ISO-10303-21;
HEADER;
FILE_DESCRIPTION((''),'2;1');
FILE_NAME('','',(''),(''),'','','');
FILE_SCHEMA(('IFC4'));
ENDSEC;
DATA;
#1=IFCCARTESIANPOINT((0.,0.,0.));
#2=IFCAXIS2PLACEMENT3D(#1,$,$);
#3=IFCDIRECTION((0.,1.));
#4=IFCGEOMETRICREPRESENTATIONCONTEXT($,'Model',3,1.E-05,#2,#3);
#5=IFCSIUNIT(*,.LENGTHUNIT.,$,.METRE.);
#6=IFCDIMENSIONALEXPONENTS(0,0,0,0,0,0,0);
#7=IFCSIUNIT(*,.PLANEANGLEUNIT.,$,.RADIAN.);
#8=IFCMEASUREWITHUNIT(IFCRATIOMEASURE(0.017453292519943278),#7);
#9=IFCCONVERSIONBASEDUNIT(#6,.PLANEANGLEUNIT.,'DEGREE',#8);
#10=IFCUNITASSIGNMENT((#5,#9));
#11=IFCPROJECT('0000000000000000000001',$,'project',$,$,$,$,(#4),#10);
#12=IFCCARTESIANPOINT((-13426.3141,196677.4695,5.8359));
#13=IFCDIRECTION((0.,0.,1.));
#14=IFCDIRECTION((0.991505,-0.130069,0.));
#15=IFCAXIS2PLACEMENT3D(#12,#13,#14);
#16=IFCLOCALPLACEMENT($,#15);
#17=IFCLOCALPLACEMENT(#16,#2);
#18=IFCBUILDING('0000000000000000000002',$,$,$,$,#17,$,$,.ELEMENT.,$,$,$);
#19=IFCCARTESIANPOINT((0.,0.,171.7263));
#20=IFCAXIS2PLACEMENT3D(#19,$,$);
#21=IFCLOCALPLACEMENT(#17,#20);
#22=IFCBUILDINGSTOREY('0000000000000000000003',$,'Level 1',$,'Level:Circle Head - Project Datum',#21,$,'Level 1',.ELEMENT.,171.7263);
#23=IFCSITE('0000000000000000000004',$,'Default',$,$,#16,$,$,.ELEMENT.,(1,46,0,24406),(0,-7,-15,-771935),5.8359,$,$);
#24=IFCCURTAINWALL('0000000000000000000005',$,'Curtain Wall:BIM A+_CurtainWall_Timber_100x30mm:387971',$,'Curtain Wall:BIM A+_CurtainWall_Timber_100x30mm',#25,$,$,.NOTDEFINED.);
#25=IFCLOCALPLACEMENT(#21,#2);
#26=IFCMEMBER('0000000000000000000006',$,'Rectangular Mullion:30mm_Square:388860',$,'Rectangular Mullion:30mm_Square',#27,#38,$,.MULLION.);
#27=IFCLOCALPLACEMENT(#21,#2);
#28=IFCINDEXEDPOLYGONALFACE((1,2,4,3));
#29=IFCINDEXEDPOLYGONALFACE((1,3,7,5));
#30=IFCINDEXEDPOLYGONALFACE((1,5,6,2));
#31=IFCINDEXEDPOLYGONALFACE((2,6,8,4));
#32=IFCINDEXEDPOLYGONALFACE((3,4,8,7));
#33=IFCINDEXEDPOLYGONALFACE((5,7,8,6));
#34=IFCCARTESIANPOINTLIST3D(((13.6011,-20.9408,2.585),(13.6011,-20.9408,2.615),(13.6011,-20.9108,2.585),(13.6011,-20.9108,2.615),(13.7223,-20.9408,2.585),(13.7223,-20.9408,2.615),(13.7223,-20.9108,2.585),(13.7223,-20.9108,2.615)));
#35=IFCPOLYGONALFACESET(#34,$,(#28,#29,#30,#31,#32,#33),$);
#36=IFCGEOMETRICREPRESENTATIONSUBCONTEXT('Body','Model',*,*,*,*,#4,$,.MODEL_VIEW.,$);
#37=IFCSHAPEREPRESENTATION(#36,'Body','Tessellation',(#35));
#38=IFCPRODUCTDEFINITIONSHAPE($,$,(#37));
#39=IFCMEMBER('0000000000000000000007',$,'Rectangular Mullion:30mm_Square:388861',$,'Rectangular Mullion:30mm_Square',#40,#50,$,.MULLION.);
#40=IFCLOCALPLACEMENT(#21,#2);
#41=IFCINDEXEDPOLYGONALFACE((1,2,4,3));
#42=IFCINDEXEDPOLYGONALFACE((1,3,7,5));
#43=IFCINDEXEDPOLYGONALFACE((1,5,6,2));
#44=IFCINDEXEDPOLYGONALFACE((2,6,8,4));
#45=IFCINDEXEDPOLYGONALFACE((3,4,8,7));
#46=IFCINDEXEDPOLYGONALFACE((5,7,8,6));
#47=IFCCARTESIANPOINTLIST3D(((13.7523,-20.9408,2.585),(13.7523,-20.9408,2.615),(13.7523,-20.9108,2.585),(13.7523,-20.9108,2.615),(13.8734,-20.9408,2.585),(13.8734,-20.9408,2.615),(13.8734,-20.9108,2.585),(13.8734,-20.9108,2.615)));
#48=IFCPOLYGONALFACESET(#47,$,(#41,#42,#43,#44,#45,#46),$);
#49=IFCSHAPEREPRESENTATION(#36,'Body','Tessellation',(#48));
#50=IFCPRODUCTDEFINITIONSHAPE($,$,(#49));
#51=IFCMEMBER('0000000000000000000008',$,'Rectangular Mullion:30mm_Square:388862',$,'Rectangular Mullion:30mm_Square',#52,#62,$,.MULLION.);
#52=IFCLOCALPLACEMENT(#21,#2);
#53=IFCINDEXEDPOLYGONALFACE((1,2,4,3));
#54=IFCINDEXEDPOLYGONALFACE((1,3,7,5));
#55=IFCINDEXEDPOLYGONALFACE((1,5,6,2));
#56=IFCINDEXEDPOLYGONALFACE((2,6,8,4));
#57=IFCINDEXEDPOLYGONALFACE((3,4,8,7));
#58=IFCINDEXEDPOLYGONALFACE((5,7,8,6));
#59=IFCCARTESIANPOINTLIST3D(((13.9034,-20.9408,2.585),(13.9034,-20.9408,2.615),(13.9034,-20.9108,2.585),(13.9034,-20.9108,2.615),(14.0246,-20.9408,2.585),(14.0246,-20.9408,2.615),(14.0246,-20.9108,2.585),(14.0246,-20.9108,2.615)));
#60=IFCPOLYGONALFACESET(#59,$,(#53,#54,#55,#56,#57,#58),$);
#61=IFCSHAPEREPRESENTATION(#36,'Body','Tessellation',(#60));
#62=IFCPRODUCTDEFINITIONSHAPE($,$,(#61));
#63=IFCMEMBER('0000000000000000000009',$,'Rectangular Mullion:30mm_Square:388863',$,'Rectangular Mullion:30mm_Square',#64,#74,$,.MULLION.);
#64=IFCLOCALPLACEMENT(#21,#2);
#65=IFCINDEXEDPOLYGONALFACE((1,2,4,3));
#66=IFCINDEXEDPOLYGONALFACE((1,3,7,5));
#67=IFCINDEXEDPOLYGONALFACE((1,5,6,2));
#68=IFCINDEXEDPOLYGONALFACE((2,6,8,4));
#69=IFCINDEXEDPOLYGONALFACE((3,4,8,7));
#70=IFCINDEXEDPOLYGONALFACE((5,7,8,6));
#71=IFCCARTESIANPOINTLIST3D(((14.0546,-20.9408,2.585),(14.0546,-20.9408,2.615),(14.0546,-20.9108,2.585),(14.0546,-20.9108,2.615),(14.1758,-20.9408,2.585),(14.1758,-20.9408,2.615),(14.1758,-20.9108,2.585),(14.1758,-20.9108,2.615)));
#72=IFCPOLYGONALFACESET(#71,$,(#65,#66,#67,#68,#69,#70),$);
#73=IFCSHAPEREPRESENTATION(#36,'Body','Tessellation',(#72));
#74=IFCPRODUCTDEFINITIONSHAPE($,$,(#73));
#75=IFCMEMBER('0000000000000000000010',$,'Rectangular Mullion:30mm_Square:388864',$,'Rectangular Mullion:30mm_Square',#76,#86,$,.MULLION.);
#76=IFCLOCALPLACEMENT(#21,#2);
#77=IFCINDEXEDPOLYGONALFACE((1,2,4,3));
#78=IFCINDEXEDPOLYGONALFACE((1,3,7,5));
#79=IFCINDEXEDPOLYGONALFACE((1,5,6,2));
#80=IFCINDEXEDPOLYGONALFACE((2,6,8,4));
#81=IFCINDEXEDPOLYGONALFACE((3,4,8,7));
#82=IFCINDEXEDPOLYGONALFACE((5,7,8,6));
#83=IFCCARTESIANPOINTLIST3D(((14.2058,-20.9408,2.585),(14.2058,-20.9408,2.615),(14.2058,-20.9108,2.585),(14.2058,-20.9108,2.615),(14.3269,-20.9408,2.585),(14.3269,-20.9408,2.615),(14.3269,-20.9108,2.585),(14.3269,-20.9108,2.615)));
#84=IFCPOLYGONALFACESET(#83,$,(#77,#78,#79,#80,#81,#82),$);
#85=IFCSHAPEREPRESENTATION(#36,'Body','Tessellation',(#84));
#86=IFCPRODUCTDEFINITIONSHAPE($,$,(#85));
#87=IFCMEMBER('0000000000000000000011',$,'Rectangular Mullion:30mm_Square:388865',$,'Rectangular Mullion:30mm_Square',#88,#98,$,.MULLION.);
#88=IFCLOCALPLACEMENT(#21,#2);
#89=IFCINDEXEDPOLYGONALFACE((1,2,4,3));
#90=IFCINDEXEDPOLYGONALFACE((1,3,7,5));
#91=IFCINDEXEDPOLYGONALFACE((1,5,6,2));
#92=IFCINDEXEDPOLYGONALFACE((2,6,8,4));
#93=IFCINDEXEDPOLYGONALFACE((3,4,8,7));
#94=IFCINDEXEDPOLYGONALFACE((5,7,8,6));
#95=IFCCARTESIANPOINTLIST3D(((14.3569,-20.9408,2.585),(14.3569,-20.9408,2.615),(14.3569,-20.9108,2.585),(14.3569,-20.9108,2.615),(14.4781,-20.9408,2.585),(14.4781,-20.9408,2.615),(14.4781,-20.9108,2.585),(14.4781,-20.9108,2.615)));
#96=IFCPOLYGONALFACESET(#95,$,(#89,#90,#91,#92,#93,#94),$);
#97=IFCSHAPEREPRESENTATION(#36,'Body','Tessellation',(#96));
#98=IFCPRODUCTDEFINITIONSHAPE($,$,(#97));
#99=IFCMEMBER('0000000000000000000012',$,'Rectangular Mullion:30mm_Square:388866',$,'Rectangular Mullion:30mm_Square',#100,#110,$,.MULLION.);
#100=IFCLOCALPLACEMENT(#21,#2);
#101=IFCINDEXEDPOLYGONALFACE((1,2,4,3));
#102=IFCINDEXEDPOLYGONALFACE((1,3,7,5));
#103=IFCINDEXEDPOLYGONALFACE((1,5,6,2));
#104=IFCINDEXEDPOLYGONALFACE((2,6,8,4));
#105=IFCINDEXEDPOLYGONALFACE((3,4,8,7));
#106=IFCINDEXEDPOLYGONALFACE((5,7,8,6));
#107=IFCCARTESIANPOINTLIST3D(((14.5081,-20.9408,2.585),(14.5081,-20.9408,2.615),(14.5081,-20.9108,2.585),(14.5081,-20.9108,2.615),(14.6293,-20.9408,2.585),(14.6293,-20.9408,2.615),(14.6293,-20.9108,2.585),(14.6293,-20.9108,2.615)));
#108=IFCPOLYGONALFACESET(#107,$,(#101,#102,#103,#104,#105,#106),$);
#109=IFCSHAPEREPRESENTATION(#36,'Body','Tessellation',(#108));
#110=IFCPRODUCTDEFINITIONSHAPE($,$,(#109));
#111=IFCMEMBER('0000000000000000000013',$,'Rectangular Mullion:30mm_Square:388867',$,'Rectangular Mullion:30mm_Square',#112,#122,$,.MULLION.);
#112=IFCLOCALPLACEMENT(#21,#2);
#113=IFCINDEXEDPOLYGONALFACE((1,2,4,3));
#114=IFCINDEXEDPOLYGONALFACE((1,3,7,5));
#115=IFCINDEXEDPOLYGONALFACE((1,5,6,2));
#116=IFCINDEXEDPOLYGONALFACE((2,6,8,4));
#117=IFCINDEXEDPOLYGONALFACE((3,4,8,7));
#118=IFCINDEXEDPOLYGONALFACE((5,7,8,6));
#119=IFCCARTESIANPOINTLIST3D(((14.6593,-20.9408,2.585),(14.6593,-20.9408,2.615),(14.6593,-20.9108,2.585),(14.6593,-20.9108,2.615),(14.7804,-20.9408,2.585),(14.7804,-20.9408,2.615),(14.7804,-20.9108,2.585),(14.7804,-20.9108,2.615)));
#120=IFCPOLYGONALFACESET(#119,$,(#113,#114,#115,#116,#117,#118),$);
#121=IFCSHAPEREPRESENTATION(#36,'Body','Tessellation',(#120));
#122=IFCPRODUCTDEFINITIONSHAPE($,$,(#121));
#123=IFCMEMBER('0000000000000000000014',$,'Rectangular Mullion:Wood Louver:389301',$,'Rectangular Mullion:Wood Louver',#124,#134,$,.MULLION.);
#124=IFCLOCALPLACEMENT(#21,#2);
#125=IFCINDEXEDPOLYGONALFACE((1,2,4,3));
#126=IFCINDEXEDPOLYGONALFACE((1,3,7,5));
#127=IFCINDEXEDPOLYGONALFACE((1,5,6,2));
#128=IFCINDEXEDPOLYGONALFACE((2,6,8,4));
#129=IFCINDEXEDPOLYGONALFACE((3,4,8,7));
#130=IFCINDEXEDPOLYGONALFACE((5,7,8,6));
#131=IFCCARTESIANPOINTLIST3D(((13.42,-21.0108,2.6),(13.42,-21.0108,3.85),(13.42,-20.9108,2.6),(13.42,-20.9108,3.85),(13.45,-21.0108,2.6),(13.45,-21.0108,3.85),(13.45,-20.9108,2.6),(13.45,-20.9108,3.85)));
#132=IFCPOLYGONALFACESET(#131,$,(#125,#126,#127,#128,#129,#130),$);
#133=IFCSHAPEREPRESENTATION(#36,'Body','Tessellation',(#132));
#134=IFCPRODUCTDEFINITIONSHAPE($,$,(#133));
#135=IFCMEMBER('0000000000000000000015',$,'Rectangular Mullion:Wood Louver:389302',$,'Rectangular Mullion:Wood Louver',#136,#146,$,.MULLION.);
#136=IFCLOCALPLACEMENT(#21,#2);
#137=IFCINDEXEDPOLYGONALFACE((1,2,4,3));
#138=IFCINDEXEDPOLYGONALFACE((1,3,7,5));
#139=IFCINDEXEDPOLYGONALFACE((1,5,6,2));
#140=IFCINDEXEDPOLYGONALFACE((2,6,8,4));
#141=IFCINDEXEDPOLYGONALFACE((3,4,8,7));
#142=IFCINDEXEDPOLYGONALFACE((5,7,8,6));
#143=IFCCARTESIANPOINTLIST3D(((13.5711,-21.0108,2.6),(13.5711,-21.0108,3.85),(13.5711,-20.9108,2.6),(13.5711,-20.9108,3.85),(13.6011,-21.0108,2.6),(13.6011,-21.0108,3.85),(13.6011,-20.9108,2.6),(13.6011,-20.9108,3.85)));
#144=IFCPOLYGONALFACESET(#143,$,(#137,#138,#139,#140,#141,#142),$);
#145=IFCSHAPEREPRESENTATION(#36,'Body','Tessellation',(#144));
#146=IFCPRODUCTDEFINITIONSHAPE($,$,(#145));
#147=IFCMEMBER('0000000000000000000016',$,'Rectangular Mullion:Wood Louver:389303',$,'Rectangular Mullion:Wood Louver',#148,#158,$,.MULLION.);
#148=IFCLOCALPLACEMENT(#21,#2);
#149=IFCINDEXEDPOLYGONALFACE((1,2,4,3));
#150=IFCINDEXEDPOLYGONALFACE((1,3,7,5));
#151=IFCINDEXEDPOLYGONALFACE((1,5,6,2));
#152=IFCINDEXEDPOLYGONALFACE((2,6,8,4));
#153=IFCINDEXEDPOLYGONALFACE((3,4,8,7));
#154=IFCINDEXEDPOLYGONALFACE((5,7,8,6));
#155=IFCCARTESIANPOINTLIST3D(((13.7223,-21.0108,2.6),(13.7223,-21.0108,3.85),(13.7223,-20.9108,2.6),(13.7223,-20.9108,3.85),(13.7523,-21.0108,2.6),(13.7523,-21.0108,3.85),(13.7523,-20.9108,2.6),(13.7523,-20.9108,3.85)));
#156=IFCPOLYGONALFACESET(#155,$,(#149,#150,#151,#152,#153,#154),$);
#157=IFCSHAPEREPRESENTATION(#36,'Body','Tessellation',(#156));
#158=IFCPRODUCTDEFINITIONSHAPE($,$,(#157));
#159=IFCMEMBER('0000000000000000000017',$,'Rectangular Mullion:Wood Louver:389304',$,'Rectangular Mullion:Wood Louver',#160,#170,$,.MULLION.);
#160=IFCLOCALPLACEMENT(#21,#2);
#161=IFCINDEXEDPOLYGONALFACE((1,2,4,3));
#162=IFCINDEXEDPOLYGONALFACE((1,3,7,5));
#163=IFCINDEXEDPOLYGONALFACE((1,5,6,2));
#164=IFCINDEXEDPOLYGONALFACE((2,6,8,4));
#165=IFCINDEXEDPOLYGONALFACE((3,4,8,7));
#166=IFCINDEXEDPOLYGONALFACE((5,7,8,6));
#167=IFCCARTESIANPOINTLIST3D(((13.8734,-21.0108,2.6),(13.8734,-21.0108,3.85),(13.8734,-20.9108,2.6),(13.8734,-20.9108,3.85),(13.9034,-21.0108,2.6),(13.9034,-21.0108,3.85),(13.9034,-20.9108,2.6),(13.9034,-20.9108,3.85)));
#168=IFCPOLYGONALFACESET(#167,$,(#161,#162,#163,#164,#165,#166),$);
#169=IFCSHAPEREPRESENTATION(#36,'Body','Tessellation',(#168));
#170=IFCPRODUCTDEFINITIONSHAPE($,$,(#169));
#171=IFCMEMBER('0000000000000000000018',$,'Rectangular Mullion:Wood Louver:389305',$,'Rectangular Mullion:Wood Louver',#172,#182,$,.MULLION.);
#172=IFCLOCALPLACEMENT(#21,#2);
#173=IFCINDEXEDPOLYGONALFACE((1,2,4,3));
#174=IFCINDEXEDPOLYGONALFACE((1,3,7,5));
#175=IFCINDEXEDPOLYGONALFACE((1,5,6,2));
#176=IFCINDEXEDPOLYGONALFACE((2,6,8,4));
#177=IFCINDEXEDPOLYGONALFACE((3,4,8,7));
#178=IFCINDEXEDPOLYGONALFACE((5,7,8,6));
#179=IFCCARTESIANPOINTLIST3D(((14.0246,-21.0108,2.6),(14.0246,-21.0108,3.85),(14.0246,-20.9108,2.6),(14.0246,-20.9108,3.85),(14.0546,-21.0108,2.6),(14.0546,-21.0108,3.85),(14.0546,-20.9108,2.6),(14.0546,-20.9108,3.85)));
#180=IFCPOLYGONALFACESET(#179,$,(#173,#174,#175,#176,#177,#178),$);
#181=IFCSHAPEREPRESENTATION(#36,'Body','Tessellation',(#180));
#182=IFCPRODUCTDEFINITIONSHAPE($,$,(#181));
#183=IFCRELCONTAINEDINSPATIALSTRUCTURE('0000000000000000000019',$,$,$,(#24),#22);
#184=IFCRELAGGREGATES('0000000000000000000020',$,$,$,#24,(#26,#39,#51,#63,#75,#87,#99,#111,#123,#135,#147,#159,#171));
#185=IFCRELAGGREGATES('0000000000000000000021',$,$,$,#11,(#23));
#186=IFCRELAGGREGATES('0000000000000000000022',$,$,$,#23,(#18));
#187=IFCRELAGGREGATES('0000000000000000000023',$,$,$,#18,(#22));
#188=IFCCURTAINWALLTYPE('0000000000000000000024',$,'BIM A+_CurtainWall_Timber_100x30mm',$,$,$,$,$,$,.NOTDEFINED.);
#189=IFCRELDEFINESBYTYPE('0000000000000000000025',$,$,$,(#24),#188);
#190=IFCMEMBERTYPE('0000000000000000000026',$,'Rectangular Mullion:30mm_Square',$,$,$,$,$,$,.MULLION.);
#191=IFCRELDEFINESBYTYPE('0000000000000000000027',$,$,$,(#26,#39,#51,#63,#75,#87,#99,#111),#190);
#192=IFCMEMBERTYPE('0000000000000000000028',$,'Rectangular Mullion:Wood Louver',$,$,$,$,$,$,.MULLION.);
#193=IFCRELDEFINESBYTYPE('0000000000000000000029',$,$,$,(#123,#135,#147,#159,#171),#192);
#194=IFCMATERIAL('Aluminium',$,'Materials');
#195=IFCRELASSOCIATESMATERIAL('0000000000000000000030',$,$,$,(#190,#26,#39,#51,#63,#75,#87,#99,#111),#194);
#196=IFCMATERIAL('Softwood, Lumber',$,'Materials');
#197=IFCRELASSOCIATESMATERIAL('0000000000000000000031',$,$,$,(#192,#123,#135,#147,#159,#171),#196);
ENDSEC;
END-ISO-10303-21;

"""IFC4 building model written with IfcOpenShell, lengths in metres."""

from ifc_helpers import new_model, entity, si_unit, converted_unit, direction, frame, origin, place, context, subcontext, project, spatial, indexed_curve, outline, extrude, source, transform, mapped, material, type_object, type_shapes, element, aggregate, save


model = new_model("IFC4")

# Units and contexts
model_context = context("Model", 3, precision=1e-05, world=origin(), true_north=direction((0.0, 1.0)))
body_context = subcontext(model_context, "Body", "Model", "MODEL_VIEW")
ifc_project = project(units=[si_unit("LENGTHUNIT", "METRE"), converted_unit("PLANEANGLEUNIT", "DEGREE", entity("IfcRatioMeasure", 0.017453292519943278), si_unit("PLANEANGLEUNIT", "RADIAN"), dimensions=[0, 0, 0, 0, 0, 0, 0])], contexts=[model_context])

# Site, building, storey
site_placement = place(None, frame((-13426.3141, 196677.4695, 5.8359), z_axis=(0.0, 0.0, 1.0), x_axis=(0.991505, -0.130069, 0.0)))
site = spatial("IfcSite", under=ifc_project, at=site_placement, Name="Default", CompositionType="ELEMENT", RefLatitude=(1, 46, 0, 24406), RefLongitude=(0, -7, -15, -771935), RefElevation=5.8359)
building_placement = place(site_placement, origin())
building = spatial("IfcBuilding", under=site, at=building_placement, CompositionType="ELEMENT")
storey_placement = place(building_placement, frame((0.0, 0.0, 171.7263)))
storey = spatial("IfcBuildingStorey", under=building, at=storey_placement, Name="Level 1", ObjectType="Level:Circle Head - Project Datum", LongName="Level 1", CompositionType="ELEMENT", Elevation=171.7263)

# Curtain wall, members
curtain_wall_type = type_object("IfcCurtainWallType", Name="BIM A+_CurtainWall_Timber_100x30mm", PredefinedType="NOTDEFINED")
curtain_wall_placement = place(storey_placement, frame((0.0, 0.0, -171.7263)))
curtain_wall = element("IfcCurtainWall", 1, at=curtain_wall_placement, inside=storey, type_object=curtain_wall_type, Name="Curtain Wall:BIM A+_CurtainWall_Timber_100x30mm:387971", ObjectType="Curtain Wall:BIM A+_CurtainWall_Timber_100x30mm", PredefinedType="NOTDEFINED")
ifc_material_1 = material(Name="Aluminium", Category="Materials")
member_type_1 = type_object("IfcMemberType", Name="Rectangular Mullion:30mm_Square", PredefinedType="MULLION", material=ifc_material_1)
shared_shape_1 = source(origin(), body_context, "Body", "SweptSolid", [
    extrude(outline(indexed_curve([(-0.015, -0.015), (0.015, -0.015), (0.015, 0.015), (-0.015, 0.015), (-0.015, -0.015)], self_intersect=False)), frame((0.0, 0.0, -0.1212), z_axis=(0.0, 0.0, 1.0), x_axis=(0.0, -1.0, 0.0)), (0.0, 0.0, 1.0), 0.1212),
])
type_shapes(member_type_1, [shared_shape_1])
member_1_placement = place(curtain_wall_placement, frame((13.7223, -20.9258, 174.3263), z_axis=(1.0, 0.0, 0.0), x_axis=(0.0, 0.0, 1.0)))
member_1 = element("IfcMember", 2, at=member_1_placement, type_object=member_type_1, material=ifc_material_1, Name="Rectangular Mullion:30mm_Square:388860", ObjectType="Rectangular Mullion:30mm_Square", PredefinedType="MULLION", context=body_context, shape_type="MappedRepresentation", body=[
    mapped(shared_shape_1, transform((0.0, 0.0, 0.0), scale=1.0)),
])
member_2_placement = place(curtain_wall_placement, frame((13.8734, -20.9258, 174.3263), z_axis=(1.0, 0.0, 0.0), x_axis=(0.0, 0.0, 1.0)))
member_2 = element("IfcMember", 3, at=member_2_placement, type_object=member_type_1, material=ifc_material_1, Name="Rectangular Mullion:30mm_Square:388861", ObjectType="Rectangular Mullion:30mm_Square", PredefinedType="MULLION", context=body_context, shape_type="MappedRepresentation", body=[
    mapped(shared_shape_1, transform((0.0, 0.0, 0.0), scale=1.0)),
])
member_3_placement = place(curtain_wall_placement, frame((14.0246, -20.9258, 174.3263), z_axis=(1.0, 0.0, 0.0), x_axis=(0.0, 0.0, 1.0)))
member_3 = element("IfcMember", 4, at=member_3_placement, type_object=member_type_1, material=ifc_material_1, Name="Rectangular Mullion:30mm_Square:388862", ObjectType="Rectangular Mullion:30mm_Square", PredefinedType="MULLION", context=body_context, shape_type="MappedRepresentation", body=[
    mapped(shared_shape_1, transform((0.0, 0.0, 0.0), scale=1.0)),
])
member_4_placement = place(curtain_wall_placement, frame((14.1758, -20.9258, 174.3263), z_axis=(1.0, 0.0, 0.0), x_axis=(0.0, 0.0, 1.0)))
member_4 = element("IfcMember", 5, at=member_4_placement, type_object=member_type_1, material=ifc_material_1, Name="Rectangular Mullion:30mm_Square:388863", ObjectType="Rectangular Mullion:30mm_Square", PredefinedType="MULLION", context=body_context, shape_type="MappedRepresentation", body=[
    mapped(shared_shape_1, transform((0.0, 0.0, 0.0), scale=1.0)),
])
member_5_placement = place(curtain_wall_placement, frame((14.3269, -20.9258, 174.3263), z_axis=(1.0, 0.0, 0.0), x_axis=(0.0, 0.0, 1.0)))
member_5 = element("IfcMember", 6, at=member_5_placement, type_object=member_type_1, material=ifc_material_1, Name="Rectangular Mullion:30mm_Square:388864", ObjectType="Rectangular Mullion:30mm_Square", PredefinedType="MULLION", context=body_context, shape_type="MappedRepresentation", body=[
    mapped(shared_shape_1, transform((0.0, 0.0, 0.0), scale=1.0)),
])
member_6_placement = place(curtain_wall_placement, frame((14.4781, -20.9258, 174.3263), z_axis=(1.0, 0.0, 0.0), x_axis=(0.0, 0.0, 1.0)))
member_6 = element("IfcMember", 7, at=member_6_placement, type_object=member_type_1, material=ifc_material_1, Name="Rectangular Mullion:30mm_Square:388865", ObjectType="Rectangular Mullion:30mm_Square", PredefinedType="MULLION", context=body_context, shape_type="MappedRepresentation", body=[
    mapped(shared_shape_1, transform((0.0, 0.0, 0.0), scale=1.0)),
])
member_7_placement = place(curtain_wall_placement, frame((14.6293, -20.9258, 174.3263), z_axis=(1.0, 0.0, 0.0), x_axis=(0.0, 0.0, 1.0)))
member_7 = element("IfcMember", 8, at=member_7_placement, type_object=member_type_1, material=ifc_material_1, Name="Rectangular Mullion:30mm_Square:388866", ObjectType="Rectangular Mullion:30mm_Square", PredefinedType="MULLION", context=body_context, shape_type="MappedRepresentation", body=[
    mapped(shared_shape_1, transform((0.0, 0.0, 0.0), scale=1.0)),
])
member_8_placement = place(curtain_wall_placement, frame((14.7804, -20.9258, 174.3263), z_axis=(1.0, 0.0, 0.0), x_axis=(0.0, 0.0, 1.0)))
member_8 = element("IfcMember", 9, at=member_8_placement, type_object=member_type_1, material=ifc_material_1, Name="Rectangular Mullion:30mm_Square:388867", ObjectType="Rectangular Mullion:30mm_Square", PredefinedType="MULLION", context=body_context, shape_type="MappedRepresentation", body=[
    mapped(shared_shape_1, transform((0.0, 0.0, 0.0), scale=1.0)),
])
ifc_material_2 = material(Name="Softwood, Lumber", Category="Materials")
member_type_2 = type_object("IfcMemberType", Name="Rectangular Mullion:Wood Louver", PredefinedType="MULLION", material=ifc_material_2)
shared_shape_2 = source(origin(), body_context, "Body", "SweptSolid", [
    extrude(outline(indexed_curve([(-0.05, -0.015), (0.05, -0.015), (0.05, 0.015), (-0.05, 0.015), (-0.05, -0.015)], self_intersect=False)), frame((0.0, 0.035, -1.25), z_axis=(0.0, 0.0, 1.0), x_axis=(0.0, -1.0, 0.0)), (0.0, 0.0, 1.0), 1.25),
])
type_shapes(member_type_2, [shared_shape_2])
member_9_placement = place(curtain_wall_placement, frame((13.435, -20.9258, 174.3263), z_axis=(0.0, 0.0, -1.0), x_axis=(1.0, 0.0, 0.0)))
member_9 = element("IfcMember", 10, at=member_9_placement, type_object=member_type_2, material=ifc_material_2, Name="Rectangular Mullion:Wood Louver:389301", ObjectType="Rectangular Mullion:Wood Louver", PredefinedType="MULLION", context=body_context, shape_type="MappedRepresentation", body=[
    mapped(shared_shape_2, transform((0.0, 0.0, 0.0), scale=1.0)),
])
member_10_placement = place(curtain_wall_placement, frame((13.5861, -20.9258, 174.3263), z_axis=(0.0, 0.0, -1.0), x_axis=(1.0, 0.0, 0.0)))
member_10 = element("IfcMember", 11, at=member_10_placement, type_object=member_type_2, material=ifc_material_2, Name="Rectangular Mullion:Wood Louver:389302", ObjectType="Rectangular Mullion:Wood Louver", PredefinedType="MULLION", context=body_context, shape_type="MappedRepresentation", body=[
    mapped(shared_shape_2, transform((0.0, 0.0, 0.0), scale=1.0)),
])
member_11_placement = place(curtain_wall_placement, frame((13.7373, -20.9258, 174.3263), z_axis=(0.0, 0.0, -1.0), x_axis=(1.0, 0.0, 0.0)))
member_11 = element("IfcMember", 12, at=member_11_placement, type_object=member_type_2, material=ifc_material_2, Name="Rectangular Mullion:Wood Louver:389303", ObjectType="Rectangular Mullion:Wood Louver", PredefinedType="MULLION", context=body_context, shape_type="MappedRepresentation", body=[
    mapped(shared_shape_2, transform((0.0, 0.0, 0.0), scale=1.0)),
])
member_12_placement = place(curtain_wall_placement, frame((13.8884, -20.9258, 174.3263), z_axis=(0.0, 0.0, -1.0), x_axis=(1.0, 0.0, 0.0)))
member_12 = element("IfcMember", 13, at=member_12_placement, type_object=member_type_2, material=ifc_material_2, Name="Rectangular Mullion:Wood Louver:389304", ObjectType="Rectangular Mullion:Wood Louver", PredefinedType="MULLION", context=body_context, shape_type="MappedRepresentation", body=[
    mapped(shared_shape_2, transform((0.0, 0.0, 0.0), scale=1.0)),
])
member_13_placement = place(curtain_wall_placement, frame((14.0396, -20.9258, 174.3263), z_axis=(0.0, 0.0, -1.0), x_axis=(1.0, 0.0, 0.0)))
member_13 = element("IfcMember", 14, at=member_13_placement, type_object=member_type_2, material=ifc_material_2, Name="Rectangular Mullion:Wood Louver:389305", ObjectType="Rectangular Mullion:Wood Louver", PredefinedType="MULLION", context=body_context, shape_type="MappedRepresentation", body=[
    mapped(shared_shape_2, transform((0.0, 0.0, 0.0), scale=1.0)),
])
aggregate(curtain_wall, [member_1, member_2, member_3, member_4, member_5, member_6, member_7, member_8, member_9, member_10, member_11, member_12, member_13])

save(model, "model.ifc")
